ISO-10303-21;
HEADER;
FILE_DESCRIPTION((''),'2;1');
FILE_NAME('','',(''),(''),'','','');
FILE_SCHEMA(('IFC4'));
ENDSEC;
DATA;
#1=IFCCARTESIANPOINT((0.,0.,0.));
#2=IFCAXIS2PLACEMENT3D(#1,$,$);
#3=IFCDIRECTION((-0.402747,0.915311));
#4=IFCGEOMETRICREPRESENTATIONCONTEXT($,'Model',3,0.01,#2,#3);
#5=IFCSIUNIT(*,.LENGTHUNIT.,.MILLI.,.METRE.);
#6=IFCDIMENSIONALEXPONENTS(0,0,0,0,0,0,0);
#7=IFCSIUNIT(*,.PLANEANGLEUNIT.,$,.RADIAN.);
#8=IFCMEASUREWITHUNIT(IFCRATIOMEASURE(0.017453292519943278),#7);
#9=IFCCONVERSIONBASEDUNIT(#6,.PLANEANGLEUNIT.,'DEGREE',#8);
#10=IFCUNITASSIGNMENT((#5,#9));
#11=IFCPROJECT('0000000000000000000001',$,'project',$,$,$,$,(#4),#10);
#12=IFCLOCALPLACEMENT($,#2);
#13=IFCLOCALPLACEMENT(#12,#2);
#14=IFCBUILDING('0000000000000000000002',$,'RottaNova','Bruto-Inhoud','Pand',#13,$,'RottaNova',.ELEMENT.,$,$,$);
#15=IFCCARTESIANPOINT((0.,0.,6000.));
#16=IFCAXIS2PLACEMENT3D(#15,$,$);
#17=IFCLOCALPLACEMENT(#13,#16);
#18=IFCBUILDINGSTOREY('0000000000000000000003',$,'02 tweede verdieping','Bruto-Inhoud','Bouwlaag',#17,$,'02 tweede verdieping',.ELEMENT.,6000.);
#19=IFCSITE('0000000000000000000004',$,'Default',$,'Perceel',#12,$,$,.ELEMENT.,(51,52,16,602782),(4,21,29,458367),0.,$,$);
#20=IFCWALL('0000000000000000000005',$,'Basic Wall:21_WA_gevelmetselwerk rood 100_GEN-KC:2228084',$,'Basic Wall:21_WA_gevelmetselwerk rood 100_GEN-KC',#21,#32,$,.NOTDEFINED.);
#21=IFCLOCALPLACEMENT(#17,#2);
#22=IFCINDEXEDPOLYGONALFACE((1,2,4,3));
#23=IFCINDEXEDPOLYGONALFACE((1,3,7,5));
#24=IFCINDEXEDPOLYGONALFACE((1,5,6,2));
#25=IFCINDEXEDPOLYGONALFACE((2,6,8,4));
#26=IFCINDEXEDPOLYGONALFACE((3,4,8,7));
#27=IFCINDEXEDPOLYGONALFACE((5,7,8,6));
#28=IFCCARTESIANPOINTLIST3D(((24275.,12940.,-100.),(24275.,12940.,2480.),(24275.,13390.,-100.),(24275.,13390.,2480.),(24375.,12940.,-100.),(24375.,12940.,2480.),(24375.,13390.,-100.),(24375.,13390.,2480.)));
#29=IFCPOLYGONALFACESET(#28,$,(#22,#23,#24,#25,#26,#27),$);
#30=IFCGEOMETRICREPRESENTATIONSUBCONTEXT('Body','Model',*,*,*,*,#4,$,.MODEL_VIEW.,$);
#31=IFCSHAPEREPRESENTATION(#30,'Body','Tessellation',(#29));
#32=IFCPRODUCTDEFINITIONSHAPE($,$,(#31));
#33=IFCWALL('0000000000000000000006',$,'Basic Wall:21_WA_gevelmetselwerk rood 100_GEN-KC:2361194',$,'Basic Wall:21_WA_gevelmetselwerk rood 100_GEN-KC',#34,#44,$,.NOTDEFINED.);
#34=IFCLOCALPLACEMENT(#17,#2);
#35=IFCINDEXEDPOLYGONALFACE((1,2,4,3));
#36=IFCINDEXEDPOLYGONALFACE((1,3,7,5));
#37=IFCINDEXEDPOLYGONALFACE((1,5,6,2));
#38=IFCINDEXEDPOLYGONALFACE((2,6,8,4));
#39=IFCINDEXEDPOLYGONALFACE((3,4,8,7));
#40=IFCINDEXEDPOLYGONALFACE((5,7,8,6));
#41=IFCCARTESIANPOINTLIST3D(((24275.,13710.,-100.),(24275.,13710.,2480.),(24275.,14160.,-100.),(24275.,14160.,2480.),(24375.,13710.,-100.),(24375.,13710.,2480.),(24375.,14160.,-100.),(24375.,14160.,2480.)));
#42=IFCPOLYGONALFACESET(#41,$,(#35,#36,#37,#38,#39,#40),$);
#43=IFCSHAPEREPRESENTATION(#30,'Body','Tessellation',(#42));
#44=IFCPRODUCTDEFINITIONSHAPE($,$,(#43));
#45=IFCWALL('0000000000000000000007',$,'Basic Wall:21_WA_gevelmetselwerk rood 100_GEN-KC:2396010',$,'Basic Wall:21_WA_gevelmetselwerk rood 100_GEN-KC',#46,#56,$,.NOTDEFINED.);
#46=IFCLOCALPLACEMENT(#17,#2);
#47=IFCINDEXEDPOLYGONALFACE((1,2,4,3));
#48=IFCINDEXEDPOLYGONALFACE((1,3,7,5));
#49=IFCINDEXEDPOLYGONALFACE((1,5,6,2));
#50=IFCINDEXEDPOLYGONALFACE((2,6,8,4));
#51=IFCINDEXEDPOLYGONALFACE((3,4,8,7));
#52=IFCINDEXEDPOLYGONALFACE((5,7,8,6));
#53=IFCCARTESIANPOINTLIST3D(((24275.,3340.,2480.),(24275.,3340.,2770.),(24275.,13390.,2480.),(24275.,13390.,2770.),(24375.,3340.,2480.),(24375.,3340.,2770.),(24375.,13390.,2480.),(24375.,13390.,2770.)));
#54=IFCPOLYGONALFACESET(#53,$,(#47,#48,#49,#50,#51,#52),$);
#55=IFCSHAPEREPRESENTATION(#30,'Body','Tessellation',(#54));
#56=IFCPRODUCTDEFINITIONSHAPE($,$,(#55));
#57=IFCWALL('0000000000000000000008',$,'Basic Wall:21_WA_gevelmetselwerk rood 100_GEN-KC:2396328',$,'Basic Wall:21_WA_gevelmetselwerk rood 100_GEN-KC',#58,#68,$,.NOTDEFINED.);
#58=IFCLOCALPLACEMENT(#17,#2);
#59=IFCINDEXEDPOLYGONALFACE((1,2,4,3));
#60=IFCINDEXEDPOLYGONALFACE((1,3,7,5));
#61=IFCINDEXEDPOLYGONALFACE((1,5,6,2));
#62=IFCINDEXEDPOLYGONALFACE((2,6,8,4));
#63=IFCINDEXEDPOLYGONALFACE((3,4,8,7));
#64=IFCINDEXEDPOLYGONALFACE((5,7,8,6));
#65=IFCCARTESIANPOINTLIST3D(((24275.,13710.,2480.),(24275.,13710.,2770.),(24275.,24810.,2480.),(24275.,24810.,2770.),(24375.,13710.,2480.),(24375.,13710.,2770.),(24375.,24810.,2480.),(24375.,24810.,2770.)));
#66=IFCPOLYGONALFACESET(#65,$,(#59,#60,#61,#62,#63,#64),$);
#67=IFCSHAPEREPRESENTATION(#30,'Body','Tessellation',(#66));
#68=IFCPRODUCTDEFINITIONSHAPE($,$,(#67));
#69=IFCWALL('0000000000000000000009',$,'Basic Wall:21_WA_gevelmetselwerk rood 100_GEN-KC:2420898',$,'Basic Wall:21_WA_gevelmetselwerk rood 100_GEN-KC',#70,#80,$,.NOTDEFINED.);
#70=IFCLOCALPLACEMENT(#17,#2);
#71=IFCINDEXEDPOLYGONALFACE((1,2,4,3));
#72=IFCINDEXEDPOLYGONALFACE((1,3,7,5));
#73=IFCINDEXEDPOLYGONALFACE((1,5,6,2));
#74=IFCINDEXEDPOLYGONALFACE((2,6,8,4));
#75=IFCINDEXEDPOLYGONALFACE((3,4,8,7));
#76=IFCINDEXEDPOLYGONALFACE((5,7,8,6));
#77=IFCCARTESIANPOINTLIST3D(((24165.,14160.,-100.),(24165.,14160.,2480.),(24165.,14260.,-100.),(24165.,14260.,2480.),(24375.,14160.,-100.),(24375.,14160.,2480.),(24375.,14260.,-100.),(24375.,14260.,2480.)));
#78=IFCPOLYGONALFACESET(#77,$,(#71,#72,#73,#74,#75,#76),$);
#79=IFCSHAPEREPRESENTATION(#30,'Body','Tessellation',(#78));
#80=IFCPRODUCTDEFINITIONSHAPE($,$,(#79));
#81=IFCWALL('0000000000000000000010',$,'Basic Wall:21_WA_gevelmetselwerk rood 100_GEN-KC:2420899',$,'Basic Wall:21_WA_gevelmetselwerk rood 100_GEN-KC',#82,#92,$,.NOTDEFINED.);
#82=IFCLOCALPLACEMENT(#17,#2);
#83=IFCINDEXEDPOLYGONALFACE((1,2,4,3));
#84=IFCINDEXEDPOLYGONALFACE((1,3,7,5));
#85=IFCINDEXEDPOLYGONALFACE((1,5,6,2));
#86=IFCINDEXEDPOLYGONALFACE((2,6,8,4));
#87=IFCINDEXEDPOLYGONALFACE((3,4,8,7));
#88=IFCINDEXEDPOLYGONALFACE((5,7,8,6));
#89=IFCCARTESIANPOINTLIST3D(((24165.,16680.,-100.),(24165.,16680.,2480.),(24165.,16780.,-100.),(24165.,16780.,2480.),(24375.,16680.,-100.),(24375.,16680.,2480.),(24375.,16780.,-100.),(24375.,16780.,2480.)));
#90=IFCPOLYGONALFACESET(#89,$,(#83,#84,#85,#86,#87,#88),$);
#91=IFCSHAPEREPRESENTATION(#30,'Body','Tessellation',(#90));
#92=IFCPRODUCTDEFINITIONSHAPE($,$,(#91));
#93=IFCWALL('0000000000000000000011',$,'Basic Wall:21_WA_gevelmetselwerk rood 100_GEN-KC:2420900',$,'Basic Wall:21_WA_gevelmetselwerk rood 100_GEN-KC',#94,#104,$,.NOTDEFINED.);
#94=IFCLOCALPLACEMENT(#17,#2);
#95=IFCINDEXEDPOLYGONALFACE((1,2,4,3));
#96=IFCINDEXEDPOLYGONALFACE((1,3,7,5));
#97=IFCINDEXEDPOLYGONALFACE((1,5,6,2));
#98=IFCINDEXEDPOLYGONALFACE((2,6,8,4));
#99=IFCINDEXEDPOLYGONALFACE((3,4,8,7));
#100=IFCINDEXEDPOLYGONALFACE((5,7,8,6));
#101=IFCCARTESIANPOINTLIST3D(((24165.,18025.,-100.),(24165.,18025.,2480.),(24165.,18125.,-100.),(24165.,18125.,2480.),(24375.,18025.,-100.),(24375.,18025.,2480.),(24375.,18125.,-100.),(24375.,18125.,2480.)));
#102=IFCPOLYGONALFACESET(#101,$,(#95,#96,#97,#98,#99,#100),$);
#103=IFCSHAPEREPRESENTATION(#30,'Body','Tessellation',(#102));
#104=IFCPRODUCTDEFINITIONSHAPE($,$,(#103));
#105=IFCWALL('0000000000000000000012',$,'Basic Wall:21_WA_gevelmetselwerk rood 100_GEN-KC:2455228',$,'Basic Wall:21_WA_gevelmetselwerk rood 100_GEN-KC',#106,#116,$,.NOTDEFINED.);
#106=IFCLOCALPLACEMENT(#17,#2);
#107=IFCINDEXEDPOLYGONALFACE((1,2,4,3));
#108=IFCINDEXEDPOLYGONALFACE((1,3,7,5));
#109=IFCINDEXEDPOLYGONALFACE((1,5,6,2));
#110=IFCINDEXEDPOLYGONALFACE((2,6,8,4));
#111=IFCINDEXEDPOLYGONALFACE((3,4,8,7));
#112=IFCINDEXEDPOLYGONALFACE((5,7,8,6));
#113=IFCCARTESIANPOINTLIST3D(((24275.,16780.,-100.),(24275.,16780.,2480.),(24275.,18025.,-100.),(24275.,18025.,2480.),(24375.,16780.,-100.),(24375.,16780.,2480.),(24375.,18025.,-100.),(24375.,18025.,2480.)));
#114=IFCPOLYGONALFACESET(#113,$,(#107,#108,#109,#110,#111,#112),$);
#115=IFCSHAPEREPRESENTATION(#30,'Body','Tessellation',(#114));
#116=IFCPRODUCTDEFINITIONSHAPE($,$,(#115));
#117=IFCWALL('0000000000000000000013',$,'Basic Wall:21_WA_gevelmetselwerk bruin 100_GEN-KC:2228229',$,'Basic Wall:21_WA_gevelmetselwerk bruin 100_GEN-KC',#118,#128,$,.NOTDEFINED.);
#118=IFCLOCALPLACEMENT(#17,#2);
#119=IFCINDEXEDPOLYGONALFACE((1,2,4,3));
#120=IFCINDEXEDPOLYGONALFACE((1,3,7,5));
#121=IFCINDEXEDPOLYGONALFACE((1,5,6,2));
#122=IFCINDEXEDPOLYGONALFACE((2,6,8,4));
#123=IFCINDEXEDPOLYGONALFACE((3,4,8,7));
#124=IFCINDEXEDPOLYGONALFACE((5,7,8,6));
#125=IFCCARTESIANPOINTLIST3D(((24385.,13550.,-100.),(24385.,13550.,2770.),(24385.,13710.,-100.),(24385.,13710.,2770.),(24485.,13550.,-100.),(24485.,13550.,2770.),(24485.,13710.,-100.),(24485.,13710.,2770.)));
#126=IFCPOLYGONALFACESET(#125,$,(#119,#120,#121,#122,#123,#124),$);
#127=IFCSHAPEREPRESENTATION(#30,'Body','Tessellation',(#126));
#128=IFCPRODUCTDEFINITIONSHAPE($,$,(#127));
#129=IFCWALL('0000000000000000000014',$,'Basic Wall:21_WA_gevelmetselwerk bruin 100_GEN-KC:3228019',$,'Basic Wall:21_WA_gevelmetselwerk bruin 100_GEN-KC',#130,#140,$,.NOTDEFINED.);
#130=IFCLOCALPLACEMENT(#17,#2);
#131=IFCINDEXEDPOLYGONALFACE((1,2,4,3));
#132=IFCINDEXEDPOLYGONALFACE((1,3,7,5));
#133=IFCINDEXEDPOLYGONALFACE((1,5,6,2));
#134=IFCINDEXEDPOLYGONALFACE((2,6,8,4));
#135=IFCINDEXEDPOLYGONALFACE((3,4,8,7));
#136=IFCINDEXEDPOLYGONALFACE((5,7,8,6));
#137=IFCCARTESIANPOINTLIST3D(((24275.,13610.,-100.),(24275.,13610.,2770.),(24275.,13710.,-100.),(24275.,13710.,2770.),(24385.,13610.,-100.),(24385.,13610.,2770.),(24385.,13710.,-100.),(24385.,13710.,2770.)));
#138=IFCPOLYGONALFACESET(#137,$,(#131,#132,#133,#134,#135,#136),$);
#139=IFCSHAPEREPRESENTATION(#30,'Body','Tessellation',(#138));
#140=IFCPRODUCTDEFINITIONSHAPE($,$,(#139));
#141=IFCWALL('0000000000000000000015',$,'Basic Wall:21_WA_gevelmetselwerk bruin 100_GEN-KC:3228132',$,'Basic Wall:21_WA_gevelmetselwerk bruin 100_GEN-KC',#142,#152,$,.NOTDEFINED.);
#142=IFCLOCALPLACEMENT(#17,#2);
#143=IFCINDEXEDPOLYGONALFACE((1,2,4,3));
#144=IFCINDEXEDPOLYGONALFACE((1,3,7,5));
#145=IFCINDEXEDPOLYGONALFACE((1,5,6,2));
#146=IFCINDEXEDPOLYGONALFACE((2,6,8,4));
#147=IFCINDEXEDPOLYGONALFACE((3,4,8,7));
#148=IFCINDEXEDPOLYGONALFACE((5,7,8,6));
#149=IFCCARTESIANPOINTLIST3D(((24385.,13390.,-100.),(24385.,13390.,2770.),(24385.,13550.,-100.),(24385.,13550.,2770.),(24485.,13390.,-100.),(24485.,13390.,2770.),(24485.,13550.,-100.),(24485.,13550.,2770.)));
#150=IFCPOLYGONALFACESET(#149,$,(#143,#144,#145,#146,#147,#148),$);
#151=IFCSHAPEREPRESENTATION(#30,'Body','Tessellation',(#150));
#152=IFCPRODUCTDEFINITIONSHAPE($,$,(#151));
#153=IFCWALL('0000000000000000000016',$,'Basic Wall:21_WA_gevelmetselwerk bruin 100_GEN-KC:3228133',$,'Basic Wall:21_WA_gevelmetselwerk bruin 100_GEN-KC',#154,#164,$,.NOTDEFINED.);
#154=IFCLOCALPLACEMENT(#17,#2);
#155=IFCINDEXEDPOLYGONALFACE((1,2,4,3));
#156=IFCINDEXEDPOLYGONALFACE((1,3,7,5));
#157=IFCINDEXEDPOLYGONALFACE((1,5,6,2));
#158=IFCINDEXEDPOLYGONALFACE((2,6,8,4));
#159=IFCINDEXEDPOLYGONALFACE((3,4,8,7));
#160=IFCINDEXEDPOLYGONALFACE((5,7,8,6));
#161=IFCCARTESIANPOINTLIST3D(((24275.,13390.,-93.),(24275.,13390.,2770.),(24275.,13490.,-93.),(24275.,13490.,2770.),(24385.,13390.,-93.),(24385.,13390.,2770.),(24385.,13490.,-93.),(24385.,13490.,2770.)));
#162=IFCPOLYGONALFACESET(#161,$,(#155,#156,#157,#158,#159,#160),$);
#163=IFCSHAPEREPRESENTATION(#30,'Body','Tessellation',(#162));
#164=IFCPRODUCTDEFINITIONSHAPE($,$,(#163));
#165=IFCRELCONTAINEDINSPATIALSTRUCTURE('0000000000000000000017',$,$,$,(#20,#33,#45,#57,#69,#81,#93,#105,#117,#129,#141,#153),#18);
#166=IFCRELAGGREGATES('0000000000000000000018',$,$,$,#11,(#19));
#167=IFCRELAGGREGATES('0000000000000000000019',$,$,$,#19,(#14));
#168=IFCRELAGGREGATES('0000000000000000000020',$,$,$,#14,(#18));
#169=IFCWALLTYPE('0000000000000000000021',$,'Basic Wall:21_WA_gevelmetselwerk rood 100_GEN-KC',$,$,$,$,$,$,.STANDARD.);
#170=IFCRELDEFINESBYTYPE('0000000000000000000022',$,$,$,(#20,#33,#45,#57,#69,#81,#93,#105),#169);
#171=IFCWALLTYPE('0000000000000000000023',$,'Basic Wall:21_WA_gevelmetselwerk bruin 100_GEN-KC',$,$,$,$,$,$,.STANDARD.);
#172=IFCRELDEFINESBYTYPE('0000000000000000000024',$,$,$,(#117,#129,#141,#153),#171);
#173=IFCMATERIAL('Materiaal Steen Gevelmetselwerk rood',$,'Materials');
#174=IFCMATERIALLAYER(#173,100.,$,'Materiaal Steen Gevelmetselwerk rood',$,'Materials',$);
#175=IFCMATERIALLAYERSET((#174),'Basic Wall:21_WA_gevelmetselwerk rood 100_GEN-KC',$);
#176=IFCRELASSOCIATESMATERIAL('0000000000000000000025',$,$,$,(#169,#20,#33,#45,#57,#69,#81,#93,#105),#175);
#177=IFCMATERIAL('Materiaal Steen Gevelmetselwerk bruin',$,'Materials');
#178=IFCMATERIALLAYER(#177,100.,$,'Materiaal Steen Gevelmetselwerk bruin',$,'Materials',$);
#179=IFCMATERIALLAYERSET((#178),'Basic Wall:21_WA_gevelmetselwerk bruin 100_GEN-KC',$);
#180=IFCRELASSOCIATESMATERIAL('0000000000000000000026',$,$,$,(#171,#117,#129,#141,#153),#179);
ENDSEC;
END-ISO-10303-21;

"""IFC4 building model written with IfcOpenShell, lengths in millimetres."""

from ifc_helpers import new_model, entity, si_unit, converted_unit, direction, frame, frame_2d, origin, place, context, subcontext, project, spatial, rectangle, extrude, material, layer, layer_set, type_object, element, save


model = new_model("IFC4")

# Units and contexts
model_context = context("Model", 3, precision=0.01, world=origin(), true_north=direction((-0.402747, 0.915311)))
body_context = subcontext(model_context, "Body", "Model", "MODEL_VIEW")
ifc_project = project(units=[si_unit("LENGTHUNIT", "METRE", prefix="MILLI"), converted_unit("PLANEANGLEUNIT", "DEGREE", entity("IfcRatioMeasure", 0.017453292519943278), si_unit("PLANEANGLEUNIT", "RADIAN"), dimensions=[0, 0, 0, 0, 0, 0, 0])], contexts=[model_context])

# Site, building, storey
site_placement = place(None, origin())
site = spatial("IfcSite", under=ifc_project, at=site_placement, Name="Default", ObjectType="Perceel", CompositionType="ELEMENT", RefLatitude=(51, 52, 16, 602782), RefLongitude=(4, 21, 29, 458367), RefElevation=0.0)
building_placement = place(site_placement, origin())
building = spatial("IfcBuilding", under=site, at=building_placement, Name="RottaNova", Description="Bruto-Inhoud", ObjectType="Pand", LongName="RottaNova", CompositionType="ELEMENT")
storey_placement = place(building_placement, frame((0.0, 0.0, 6000.0)))
storey = spatial("IfcBuildingStorey", under=building, at=storey_placement, Name="02 tweede verdieping", Description="Bruto-Inhoud", ObjectType="Bouwlaag", LongName="02 tweede verdieping", CompositionType="ELEMENT", Elevation=6000.0)

# Walls
ifc_material_1 = material(Name="Materiaal Steen Gevelmetselwerk rood", Category="Materials")
ifc_layer_1 = layer(ifc_material_1, 100.0, Name="Materiaal Steen Gevelmetselwerk rood", Category="Materials")
ifc_layer_set_1 = layer_set([ifc_layer_1], Name="Basic Wall:21_WA_gevelmetselwerk rood 100_GEN-KC")
wall_type_1 = type_object("IfcWallType", Name="Basic Wall:21_WA_gevelmetselwerk rood 100_GEN-KC", PredefinedType="STANDARD", material=ifc_layer_set_1)
wall_1_placement = place(storey_placement, frame((24325.0, 13390.0, -100.0), z_axis=(0.0, 0.0, 1.0), x_axis=(0.0, -1.0, 0.0)))
element("IfcWall", 1, at=wall_1_placement, inside=storey, type_object=wall_type_1, material=ifc_layer_set_1, Name="Basic Wall:21_WA_gevelmetselwerk rood 100_GEN-KC:2228084", ObjectType="Basic Wall:21_WA_gevelmetselwerk rood 100_GEN-KC", PredefinedType="NOTDEFINED", context=body_context, shape_type="SweptSolid", body=[
    extrude(rectangle(XDim=450.0, YDim=100.0, at=frame_2d((225.0, 0.0), x_axis=(-1.0, 0.0))), origin(), (0.0, 0.0, 1.0), 2580.0),
])
wall_2_placement = place(storey_placement, frame((24325.0, 13710.0, -100.0), z_axis=(0.0, 0.0, 1.0), x_axis=(0.0, 1.0, 0.0)))
element("IfcWall", 2, at=wall_2_placement, inside=storey, type_object=wall_type_1, material=ifc_layer_set_1, Name="Basic Wall:21_WA_gevelmetselwerk rood 100_GEN-KC:2361194", ObjectType="Basic Wall:21_WA_gevelmetselwerk rood 100_GEN-KC", PredefinedType="NOTDEFINED", context=body_context, shape_type="SweptSolid", body=[
    extrude(rectangle(XDim=450.0, YDim=100.0, at=frame_2d((225.0, 0.0), x_axis=(-1.0, 0.0))), origin(), (0.0, 0.0, 1.0), 2580.0),
])
wall_3_placement = place(storey_placement, frame((24325.0, 13390.0, 2480.0), z_axis=(0.0, 0.0, 1.0), x_axis=(0.0, -1.0, 0.0)))
element("IfcWall", 3, at=wall_3_placement, inside=storey, type_object=wall_type_1, material=ifc_layer_set_1, Name="Basic Wall:21_WA_gevelmetselwerk rood 100_GEN-KC:2396010", ObjectType="Basic Wall:21_WA_gevelmetselwerk rood 100_GEN-KC", PredefinedType="NOTDEFINED", context=body_context, shape_type="SweptSolid", body=[
    extrude(rectangle(XDim=10050.0, YDim=100.0, at=frame_2d((5025.0, 0.0), x_axis=(-1.0, 0.0))), origin(), (0.0, 0.0, 1.0), 290.0),
])
wall_4_placement = place(storey_placement, frame((24325.0, 13710.0, 2480.0), z_axis=(0.0, 0.0, 1.0), x_axis=(0.0, 1.0, 0.0)))
element("IfcWall", 4, at=wall_4_placement, inside=storey, type_object=wall_type_1, material=ifc_layer_set_1, Name="Basic Wall:21_WA_gevelmetselwerk rood 100_GEN-KC:2396328", ObjectType="Basic Wall:21_WA_gevelmetselwerk rood 100_GEN-KC", PredefinedType="NOTDEFINED", context=body_context, shape_type="SweptSolid", body=[
    extrude(rectangle(XDim=11100.0, YDim=100.0, at=frame_2d((5550.0, 0.0), x_axis=(-1.0, 0.0))), origin(), (0.0, 0.0, 1.0), 290.0),
])
wall_5_placement = place(storey_placement, frame((24375.0, 14210.0, -100.0), z_axis=(0.0, 0.0, 1.0), x_axis=(-1.0, 0.0, 0.0)))
element("IfcWall", 5, at=wall_5_placement, inside=storey, type_object=wall_type_1, material=ifc_layer_set_1, Name="Basic Wall:21_WA_gevelmetselwerk rood 100_GEN-KC:2420898", ObjectType="Basic Wall:21_WA_gevelmetselwerk rood 100_GEN-KC", PredefinedType="NOTDEFINED", context=body_context, shape_type="SweptSolid", body=[
    extrude(rectangle(XDim=210.0, YDim=100.0, at=frame_2d((105.0, 0.0), x_axis=(-1.0, 0.0))), origin(), (0.0, 0.0, 1.0), 2580.0),
])
wall_6_placement = place(storey_placement, frame((24375.0, 16730.0, -100.0), z_axis=(0.0, 0.0, 1.0), x_axis=(-1.0, 0.0, 0.0)))
element("IfcWall", 6, at=wall_6_placement, inside=storey, type_object=wall_type_1, material=ifc_layer_set_1, Name="Basic Wall:21_WA_gevelmetselwerk rood 100_GEN-KC:2420899", ObjectType="Basic Wall:21_WA_gevelmetselwerk rood 100_GEN-KC", PredefinedType="NOTDEFINED", context=body_context, shape_type="SweptSolid", body=[
    extrude(rectangle(XDim=210.0, YDim=100.0, at=frame_2d((105.0, 0.0), x_axis=(-1.0, 0.0))), origin(), (0.0, 0.0, 1.0), 2580.0),
])
wall_7_placement = place(storey_placement, frame((24375.0, 18075.0, -100.0), z_axis=(0.0, 0.0, 1.0), x_axis=(-1.0, 0.0, 0.0)))
element("IfcWall", 7, at=wall_7_placement, inside=storey, type_object=wall_type_1, material=ifc_layer_set_1, Name="Basic Wall:21_WA_gevelmetselwerk rood 100_GEN-KC:2420900", ObjectType="Basic Wall:21_WA_gevelmetselwerk rood 100_GEN-KC", PredefinedType="NOTDEFINED", context=body_context, shape_type="SweptSolid", body=[
    extrude(rectangle(XDim=210.0, YDim=100.0, at=frame_2d((105.0, 0.0), x_axis=(-1.0, 0.0))), origin(), (0.0, 0.0, 1.0), 2580.0),
])
wall_8_placement = place(storey_placement, frame((24325.0, 16780.0, -100.0), z_axis=(0.0, 0.0, 1.0), x_axis=(0.0, 1.0, 0.0)))
element("IfcWall", 8, at=wall_8_placement, inside=storey, type_object=wall_type_1, material=ifc_layer_set_1, Name="Basic Wall:21_WA_gevelmetselwerk rood 100_GEN-KC:2455228", ObjectType="Basic Wall:21_WA_gevelmetselwerk rood 100_GEN-KC", PredefinedType="NOTDEFINED", context=body_context, shape_type="SweptSolid", body=[
    extrude(rectangle(XDim=1245.0, YDim=100.0, at=frame_2d((622.5, 0.0), x_axis=(-1.0, 0.0))), origin(), (0.0, 0.0, 1.0), 2580.0),
])
ifc_material_2 = material(Name="Materiaal Steen Gevelmetselwerk bruin", Category="Materials")
ifc_layer_2 = layer(ifc_material_2, 100.0, Name="Materiaal Steen Gevelmetselwerk bruin", Category="Materials")
ifc_layer_set_2 = layer_set([ifc_layer_2], Name="Basic Wall:21_WA_gevelmetselwerk bruin 100_GEN-KC")
wall_type_2 = type_object("IfcWallType", Name="Basic Wall:21_WA_gevelmetselwerk bruin 100_GEN-KC", PredefinedType="STANDARD", material=ifc_layer_set_2)
wall_9_placement = place(storey_placement, frame((24435.0, 13710.0, -100.0), z_axis=(0.0, 0.0, 1.0), x_axis=(0.0, -1.0, 0.0)))
element("IfcWall", 9, at=wall_9_placement, inside=storey, type_object=wall_type_2, material=ifc_layer_set_2, Name="Basic Wall:21_WA_gevelmetselwerk bruin 100_GEN-KC:2228229", ObjectType="Basic Wall:21_WA_gevelmetselwerk bruin 100_GEN-KC", PredefinedType="NOTDEFINED", context=body_context, shape_type="SweptSolid", body=[
    extrude(rectangle(XDim=160.0, YDim=100.0, at=frame_2d((80.0, 0.0), x_axis=(-1.0, 0.0))), origin(), (0.0, 0.0, 1.0), 2870.0),
])
wall_10_placement = place(storey_placement, frame((24385.0, 13660.0, -100.0), z_axis=(0.0, 0.0, 1.0), x_axis=(-1.0, 0.0, 0.0)))
element("IfcWall", 10, at=wall_10_placement, inside=storey, type_object=wall_type_2, material=ifc_layer_set_2, Name="Basic Wall:21_WA_gevelmetselwerk bruin 100_GEN-KC:3228019", ObjectType="Basic Wall:21_WA_gevelmetselwerk bruin 100_GEN-KC", PredefinedType="NOTDEFINED", context=body_context, shape_type="SweptSolid", body=[
    extrude(rectangle(XDim=110.0, YDim=100.0, at=frame_2d((55.0, 0.0), x_axis=(-1.0, 0.0))), origin(), (0.0, 0.0, 1.0), 2870.0),
])
wall_11_placement = place(storey_placement, frame((24435.0, 13390.0, -100.0), z_axis=(0.0, 0.0, 1.0), x_axis=(0.0, 1.0, 0.0)))
element("IfcWall", 11, at=wall_11_placement, inside=storey, type_object=wall_type_2, material=ifc_layer_set_2, Name="Basic Wall:21_WA_gevelmetselwerk bruin 100_GEN-KC:3228132", ObjectType="Basic Wall:21_WA_gevelmetselwerk bruin 100_GEN-KC", PredefinedType="NOTDEFINED", context=body_context, shape_type="SweptSolid", body=[
    extrude(rectangle(XDim=160.0, YDim=100.0, at=frame_2d((80.0, 0.0), x_axis=(-1.0, 0.0))), origin(), (0.0, 0.0, 1.0), 2870.0),
])
wall_12_placement = place(storey_placement, frame((24385.0, 13440.0, -93.0), z_axis=(0.0, 0.0, 1.0), x_axis=(-1.0, 0.0, 0.0)))
element("IfcWall", 12, at=wall_12_placement, inside=storey, type_object=wall_type_2, material=ifc_layer_set_2, Name="Basic Wall:21_WA_gevelmetselwerk bruin 100_GEN-KC:3228133", ObjectType="Basic Wall:21_WA_gevelmetselwerk bruin 100_GEN-KC", PredefinedType="NOTDEFINED", context=body_context, shape_type="SweptSolid", body=[
    extrude(rectangle(XDim=110.0, YDim=100.0, at=frame_2d((55.0, 0.0), x_axis=(-1.0, 0.0))), origin(), (0.0, 0.0, 1.0), 2863.0),
])

save(model, "model.ifc")
